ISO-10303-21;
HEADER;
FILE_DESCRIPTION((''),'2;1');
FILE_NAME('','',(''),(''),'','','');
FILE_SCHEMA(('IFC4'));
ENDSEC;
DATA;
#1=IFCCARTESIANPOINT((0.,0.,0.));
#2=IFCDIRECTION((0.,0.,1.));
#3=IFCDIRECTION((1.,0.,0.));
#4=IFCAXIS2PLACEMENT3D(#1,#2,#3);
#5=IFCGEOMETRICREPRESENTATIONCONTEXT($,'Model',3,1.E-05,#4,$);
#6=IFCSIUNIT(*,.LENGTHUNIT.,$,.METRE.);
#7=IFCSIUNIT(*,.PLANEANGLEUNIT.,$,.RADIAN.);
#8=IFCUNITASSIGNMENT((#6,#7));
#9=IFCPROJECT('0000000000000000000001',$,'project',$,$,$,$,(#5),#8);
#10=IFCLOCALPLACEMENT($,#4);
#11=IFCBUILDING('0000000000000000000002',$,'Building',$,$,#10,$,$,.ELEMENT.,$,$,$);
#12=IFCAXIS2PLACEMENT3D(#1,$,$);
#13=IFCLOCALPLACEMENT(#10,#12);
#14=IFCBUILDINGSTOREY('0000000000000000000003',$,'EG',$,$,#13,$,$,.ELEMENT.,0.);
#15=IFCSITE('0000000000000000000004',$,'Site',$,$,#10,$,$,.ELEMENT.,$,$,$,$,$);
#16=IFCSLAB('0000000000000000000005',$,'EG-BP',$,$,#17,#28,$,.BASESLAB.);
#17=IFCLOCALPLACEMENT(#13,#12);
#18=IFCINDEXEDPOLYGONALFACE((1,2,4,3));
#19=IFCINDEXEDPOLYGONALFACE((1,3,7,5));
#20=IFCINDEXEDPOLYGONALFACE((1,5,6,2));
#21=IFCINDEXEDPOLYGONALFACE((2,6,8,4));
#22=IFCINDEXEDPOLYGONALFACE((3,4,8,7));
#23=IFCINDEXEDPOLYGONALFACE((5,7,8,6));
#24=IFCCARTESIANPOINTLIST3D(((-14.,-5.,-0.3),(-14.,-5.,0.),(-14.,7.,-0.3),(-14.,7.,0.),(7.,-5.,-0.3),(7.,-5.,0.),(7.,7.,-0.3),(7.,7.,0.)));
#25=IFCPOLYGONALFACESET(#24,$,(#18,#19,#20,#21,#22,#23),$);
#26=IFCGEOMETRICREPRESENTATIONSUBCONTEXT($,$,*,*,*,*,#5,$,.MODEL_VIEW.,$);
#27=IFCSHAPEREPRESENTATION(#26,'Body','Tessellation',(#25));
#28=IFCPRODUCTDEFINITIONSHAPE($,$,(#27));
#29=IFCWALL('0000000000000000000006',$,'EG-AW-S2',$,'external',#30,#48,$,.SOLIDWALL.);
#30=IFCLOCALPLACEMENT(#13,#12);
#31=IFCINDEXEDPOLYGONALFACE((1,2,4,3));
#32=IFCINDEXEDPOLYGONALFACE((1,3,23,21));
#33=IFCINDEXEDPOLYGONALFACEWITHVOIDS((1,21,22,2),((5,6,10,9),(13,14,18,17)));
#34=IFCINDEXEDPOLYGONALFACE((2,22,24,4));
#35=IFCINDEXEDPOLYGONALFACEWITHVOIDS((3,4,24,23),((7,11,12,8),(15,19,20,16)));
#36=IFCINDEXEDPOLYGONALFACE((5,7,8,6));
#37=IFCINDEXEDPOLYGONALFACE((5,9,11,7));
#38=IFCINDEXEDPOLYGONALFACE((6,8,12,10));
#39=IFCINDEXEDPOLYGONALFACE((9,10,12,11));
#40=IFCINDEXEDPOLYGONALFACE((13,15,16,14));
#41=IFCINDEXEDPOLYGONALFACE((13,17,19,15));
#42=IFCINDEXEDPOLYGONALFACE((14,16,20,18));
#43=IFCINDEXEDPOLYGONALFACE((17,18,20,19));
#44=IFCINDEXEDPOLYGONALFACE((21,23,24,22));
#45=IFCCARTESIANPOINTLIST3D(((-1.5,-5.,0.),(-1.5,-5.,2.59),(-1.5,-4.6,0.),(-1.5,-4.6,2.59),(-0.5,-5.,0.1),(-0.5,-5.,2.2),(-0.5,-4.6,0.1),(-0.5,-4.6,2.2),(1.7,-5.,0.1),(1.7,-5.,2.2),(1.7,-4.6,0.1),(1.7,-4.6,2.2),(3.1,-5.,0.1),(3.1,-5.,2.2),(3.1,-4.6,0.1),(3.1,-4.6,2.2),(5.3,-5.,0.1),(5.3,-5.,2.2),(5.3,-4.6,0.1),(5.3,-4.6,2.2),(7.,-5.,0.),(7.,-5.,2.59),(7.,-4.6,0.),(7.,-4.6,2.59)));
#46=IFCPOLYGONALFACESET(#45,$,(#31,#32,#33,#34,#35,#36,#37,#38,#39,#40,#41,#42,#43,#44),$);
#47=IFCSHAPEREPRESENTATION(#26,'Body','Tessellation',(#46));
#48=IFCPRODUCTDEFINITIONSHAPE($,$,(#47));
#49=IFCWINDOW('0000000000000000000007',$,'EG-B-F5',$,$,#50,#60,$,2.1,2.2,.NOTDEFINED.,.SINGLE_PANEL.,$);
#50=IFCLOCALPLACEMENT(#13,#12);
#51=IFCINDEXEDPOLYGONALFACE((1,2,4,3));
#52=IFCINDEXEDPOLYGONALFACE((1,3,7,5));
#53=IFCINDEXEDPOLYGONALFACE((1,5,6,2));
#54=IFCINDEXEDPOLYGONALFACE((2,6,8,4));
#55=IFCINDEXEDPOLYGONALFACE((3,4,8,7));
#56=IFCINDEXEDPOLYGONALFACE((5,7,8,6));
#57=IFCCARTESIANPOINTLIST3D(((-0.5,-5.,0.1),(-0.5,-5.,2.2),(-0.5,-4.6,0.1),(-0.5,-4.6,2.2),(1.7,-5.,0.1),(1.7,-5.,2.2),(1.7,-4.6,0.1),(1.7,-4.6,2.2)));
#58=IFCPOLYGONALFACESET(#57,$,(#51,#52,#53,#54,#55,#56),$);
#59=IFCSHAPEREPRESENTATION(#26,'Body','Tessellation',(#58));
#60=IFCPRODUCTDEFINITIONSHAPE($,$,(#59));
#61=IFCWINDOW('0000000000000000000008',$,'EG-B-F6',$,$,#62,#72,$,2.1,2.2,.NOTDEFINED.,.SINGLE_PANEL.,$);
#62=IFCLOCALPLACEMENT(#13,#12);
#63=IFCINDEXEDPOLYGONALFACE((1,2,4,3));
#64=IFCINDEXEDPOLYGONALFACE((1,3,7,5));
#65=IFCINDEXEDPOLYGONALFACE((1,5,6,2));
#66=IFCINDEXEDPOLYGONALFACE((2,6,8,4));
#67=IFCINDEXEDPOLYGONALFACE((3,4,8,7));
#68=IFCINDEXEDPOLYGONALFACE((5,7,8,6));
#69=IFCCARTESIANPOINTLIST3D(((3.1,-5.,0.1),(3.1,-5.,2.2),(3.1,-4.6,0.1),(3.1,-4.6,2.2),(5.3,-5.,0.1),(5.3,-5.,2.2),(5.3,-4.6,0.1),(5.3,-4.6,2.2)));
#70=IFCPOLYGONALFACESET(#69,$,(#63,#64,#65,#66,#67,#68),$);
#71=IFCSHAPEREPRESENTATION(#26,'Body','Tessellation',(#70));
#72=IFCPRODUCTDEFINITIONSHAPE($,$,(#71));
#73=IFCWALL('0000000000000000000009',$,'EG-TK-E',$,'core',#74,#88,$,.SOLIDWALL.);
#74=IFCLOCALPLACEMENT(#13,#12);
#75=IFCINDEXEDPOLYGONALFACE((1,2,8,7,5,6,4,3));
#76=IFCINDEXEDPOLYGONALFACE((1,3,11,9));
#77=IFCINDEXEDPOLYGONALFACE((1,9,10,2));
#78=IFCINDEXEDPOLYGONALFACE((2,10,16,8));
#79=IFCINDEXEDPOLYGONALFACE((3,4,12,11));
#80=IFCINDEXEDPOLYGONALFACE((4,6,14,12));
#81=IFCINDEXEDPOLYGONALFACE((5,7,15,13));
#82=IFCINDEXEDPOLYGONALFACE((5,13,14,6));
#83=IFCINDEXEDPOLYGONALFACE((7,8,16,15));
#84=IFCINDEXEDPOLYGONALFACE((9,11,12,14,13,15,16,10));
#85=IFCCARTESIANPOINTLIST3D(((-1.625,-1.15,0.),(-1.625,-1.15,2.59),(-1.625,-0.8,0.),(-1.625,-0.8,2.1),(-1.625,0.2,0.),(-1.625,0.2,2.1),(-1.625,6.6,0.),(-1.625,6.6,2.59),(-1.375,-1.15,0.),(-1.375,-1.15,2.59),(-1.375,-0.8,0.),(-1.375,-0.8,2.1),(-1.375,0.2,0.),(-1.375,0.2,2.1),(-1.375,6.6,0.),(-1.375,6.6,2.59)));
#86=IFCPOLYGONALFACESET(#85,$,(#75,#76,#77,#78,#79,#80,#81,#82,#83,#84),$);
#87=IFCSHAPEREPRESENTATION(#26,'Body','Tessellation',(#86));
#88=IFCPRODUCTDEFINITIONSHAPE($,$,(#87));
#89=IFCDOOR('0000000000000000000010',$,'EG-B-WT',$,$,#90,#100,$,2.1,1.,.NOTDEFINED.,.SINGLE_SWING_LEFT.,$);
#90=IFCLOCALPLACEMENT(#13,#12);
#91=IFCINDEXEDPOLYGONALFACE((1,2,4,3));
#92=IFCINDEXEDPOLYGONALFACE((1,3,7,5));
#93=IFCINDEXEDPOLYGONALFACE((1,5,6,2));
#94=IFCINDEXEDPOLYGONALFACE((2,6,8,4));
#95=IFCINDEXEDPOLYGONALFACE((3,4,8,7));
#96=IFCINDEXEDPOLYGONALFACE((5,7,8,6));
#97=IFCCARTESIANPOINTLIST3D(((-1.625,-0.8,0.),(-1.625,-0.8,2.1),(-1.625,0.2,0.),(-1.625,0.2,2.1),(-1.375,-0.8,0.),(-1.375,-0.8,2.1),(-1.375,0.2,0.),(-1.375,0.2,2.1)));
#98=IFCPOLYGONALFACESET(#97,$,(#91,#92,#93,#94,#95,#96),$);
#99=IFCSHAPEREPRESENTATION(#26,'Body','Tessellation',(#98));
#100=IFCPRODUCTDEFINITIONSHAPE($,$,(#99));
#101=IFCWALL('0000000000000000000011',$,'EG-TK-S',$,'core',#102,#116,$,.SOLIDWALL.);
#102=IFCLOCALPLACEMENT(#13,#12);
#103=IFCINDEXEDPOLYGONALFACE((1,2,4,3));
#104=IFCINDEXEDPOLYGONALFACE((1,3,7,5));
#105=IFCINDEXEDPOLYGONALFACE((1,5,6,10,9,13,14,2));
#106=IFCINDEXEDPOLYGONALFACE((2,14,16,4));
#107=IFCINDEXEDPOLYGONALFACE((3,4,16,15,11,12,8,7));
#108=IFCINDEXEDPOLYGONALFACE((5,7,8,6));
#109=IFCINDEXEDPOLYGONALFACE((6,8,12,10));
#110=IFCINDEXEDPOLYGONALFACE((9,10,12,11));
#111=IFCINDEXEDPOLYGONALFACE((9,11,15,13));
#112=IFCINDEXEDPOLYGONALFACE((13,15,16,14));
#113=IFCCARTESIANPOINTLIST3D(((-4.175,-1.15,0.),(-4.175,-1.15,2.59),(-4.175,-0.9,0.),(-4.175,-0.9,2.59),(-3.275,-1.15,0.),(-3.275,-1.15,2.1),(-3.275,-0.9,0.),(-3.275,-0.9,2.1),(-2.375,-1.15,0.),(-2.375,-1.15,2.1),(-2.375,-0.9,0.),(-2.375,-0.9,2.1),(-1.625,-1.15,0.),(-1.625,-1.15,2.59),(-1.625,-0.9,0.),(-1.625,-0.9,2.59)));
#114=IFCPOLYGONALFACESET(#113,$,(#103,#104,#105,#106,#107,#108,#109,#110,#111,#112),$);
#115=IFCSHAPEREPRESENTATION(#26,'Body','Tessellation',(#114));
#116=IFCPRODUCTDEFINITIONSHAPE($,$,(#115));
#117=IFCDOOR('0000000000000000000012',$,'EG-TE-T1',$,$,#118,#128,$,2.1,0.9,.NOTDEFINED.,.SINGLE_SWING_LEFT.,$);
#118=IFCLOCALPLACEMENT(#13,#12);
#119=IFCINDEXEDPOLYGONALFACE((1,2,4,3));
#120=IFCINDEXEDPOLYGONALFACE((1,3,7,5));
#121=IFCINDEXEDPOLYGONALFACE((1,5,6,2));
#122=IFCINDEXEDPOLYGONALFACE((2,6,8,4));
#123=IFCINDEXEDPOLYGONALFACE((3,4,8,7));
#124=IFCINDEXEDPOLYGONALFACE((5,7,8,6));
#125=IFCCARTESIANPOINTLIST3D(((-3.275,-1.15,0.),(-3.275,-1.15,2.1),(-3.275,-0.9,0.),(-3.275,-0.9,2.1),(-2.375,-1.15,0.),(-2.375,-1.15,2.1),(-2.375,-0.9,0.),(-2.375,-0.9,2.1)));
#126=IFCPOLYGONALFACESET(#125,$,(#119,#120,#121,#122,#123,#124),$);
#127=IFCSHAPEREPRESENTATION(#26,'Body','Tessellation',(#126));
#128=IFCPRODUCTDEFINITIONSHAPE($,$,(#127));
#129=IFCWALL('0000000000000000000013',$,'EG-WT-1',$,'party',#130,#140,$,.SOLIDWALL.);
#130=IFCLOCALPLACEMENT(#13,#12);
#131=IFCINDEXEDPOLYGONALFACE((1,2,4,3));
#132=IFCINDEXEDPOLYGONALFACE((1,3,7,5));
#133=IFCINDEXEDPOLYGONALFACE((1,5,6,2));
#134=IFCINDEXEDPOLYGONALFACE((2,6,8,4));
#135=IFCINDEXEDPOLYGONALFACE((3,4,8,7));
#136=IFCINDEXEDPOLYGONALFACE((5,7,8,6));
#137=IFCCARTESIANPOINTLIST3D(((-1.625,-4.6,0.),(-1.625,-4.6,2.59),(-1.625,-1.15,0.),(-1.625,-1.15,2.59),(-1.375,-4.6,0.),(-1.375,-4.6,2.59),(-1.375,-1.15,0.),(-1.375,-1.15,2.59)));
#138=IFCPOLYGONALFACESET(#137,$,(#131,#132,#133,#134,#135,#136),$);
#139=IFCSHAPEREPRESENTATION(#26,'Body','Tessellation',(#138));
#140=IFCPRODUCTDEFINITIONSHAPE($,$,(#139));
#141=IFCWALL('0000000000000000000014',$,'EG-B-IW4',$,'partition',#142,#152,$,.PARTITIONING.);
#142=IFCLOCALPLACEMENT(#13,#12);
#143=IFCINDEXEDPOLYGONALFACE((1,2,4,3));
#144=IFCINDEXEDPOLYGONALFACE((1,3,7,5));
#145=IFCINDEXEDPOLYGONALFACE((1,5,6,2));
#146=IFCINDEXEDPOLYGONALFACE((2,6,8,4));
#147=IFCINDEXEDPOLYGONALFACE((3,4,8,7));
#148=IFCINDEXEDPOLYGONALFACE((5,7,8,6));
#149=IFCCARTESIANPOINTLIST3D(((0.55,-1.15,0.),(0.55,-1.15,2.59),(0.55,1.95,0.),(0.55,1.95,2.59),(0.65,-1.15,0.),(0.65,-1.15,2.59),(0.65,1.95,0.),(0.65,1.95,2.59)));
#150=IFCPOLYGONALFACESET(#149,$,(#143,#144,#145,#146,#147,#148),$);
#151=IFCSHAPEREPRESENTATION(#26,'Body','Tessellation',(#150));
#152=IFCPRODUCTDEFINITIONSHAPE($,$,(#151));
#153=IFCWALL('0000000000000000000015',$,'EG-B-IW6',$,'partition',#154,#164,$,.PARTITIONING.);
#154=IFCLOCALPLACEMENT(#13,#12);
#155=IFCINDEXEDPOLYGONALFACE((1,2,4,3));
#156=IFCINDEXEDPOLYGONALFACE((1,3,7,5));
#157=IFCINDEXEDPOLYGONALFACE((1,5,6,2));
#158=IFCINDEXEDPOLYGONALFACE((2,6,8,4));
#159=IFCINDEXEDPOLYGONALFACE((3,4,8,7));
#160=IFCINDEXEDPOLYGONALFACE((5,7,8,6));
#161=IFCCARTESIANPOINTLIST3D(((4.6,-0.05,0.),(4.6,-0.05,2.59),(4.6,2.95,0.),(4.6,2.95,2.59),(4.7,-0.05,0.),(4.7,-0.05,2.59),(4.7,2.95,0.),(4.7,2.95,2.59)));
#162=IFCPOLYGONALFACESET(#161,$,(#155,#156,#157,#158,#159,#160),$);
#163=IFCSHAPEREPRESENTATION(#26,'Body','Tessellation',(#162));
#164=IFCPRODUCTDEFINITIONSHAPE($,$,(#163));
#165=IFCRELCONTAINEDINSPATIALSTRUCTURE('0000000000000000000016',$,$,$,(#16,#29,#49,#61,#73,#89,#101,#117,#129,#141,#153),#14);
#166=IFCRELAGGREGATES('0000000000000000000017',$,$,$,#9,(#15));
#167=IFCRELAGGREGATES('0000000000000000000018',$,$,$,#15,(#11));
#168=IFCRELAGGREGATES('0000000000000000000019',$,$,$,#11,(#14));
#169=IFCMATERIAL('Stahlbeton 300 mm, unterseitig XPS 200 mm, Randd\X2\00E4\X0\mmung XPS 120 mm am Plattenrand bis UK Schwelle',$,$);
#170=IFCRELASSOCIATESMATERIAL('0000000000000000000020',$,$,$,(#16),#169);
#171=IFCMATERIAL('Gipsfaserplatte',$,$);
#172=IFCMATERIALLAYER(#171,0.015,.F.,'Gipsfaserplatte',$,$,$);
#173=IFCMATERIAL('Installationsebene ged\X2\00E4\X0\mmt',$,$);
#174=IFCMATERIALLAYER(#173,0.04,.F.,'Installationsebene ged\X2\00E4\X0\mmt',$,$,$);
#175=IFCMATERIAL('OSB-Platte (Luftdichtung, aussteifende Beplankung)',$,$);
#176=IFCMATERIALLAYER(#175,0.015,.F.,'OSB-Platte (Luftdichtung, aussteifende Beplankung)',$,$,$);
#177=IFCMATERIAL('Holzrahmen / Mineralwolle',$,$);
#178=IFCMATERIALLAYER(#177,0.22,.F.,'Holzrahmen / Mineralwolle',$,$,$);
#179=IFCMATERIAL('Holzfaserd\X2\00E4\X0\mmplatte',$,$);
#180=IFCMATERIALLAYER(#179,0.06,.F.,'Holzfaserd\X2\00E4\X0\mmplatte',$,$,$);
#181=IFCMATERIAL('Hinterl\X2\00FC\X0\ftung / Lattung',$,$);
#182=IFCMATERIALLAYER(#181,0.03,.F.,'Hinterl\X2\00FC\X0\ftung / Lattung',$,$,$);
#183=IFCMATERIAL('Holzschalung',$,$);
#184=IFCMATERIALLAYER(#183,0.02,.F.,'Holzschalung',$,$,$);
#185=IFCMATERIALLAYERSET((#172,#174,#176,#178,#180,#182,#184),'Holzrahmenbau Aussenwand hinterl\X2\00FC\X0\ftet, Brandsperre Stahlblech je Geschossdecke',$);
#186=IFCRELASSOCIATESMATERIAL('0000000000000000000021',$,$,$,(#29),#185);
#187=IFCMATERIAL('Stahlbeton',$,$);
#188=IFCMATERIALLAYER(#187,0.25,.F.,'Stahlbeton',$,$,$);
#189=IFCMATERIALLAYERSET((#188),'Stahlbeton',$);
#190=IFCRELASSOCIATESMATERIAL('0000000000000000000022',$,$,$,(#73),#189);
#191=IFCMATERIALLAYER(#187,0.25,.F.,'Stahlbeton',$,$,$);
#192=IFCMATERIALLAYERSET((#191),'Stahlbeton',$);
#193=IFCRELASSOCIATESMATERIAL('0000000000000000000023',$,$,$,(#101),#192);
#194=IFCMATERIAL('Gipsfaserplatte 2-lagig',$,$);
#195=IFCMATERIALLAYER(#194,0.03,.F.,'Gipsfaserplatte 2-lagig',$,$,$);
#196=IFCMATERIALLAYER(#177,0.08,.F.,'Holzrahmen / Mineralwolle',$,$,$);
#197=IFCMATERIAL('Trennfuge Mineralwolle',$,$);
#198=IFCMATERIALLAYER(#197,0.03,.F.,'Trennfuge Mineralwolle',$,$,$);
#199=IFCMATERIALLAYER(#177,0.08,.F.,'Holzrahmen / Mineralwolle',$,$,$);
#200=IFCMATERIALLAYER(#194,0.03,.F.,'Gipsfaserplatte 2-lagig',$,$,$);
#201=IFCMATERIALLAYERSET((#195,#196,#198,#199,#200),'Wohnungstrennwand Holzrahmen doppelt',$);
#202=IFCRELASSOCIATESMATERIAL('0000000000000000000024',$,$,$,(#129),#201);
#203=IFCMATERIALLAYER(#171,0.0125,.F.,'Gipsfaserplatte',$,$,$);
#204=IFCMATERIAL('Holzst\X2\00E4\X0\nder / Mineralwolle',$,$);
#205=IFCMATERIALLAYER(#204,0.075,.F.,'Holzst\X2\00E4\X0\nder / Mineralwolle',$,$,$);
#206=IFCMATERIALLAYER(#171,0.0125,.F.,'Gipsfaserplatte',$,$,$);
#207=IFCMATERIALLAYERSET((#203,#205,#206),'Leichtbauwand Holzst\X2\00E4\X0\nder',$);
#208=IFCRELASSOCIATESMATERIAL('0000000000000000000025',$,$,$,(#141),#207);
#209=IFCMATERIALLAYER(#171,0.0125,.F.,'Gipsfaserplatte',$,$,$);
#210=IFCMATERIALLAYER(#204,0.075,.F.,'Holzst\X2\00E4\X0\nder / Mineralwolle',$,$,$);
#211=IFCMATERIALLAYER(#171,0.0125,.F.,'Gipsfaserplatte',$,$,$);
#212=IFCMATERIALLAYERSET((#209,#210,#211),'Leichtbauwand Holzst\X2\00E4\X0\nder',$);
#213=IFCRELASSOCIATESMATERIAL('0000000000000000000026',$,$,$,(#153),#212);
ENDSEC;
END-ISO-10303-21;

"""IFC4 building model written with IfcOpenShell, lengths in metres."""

from ifc_helpers import new_model, si_unit, frame, frame_2d, origin, origin_with_axes, place, context, subcontext, project, spatial, polyline, rectangle, outline, extrude, material, layer, layer_set, element, fill, save


model = new_model("IFC4")

# Units and contexts
model_context = context("Model", 3, precision=1e-05, world=origin_with_axes())
sub_context = subcontext(model_context, None, None, "MODEL_VIEW")
ifc_project = project(units=[si_unit("LENGTHUNIT", "METRE"), si_unit("PLANEANGLEUNIT", "RADIAN")], contexts=[model_context])

# Site, building, storey
placement = place(None, origin_with_axes())
site = spatial("IfcSite", under=ifc_project, at=placement, Name="Site", CompositionType="ELEMENT")
building = spatial("IfcBuilding", under=site, at=placement, Name="Building", CompositionType="ELEMENT")
storey_placement = place(placement, origin())
storey = spatial("IfcBuildingStorey", under=building, at=storey_placement, Name="EG", CompositionType="ELEMENT", Elevation=0.0)

# Slab
ifc_material_1 = material(Name="Stahlbeton 300 mm, unterseitig XPS 200 mm, Randdämmung XPS 120 mm am Plattenrand bis UK Schwelle")
slab_placement = place(storey_placement, frame((0.0, 0.0, -0.3)))
element("IfcSlab", 1, at=slab_placement, inside=storey, material=ifc_material_1, Name="EG-BP", PredefinedType="BASESLAB", context=sub_context, shape_type="SweptSolid", body=[
    extrude(outline(polyline([(-14.0, -5.0), (7.0, -5.0), (7.0, 7.0), (-14.0, 7.0), (-14.0, -5.0)])), origin(), (0.0, 0.0, 1.0), 0.3),
])

# Wall, openings, windows
ifc_material_2 = material(Name="Gipsfaserplatte")
ifc_layer_1 = layer(ifc_material_2, 0.015, ventilated=False, Name="Gipsfaserplatte")
ifc_material_3 = material(Name="Installationsebene gedämmt")
ifc_layer_2 = layer(ifc_material_3, 0.04, ventilated=False, Name="Installationsebene gedämmt")
ifc_material_4 = material(Name="OSB-Platte (Luftdichtung, aussteifende Beplankung)")
ifc_layer_3 = layer(ifc_material_4, 0.015, ventilated=False, Name="OSB-Platte (Luftdichtung, aussteifende Beplankung)")
ifc_material_5 = material(Name="Holzrahmen / Mineralwolle")
ifc_layer_4 = layer(ifc_material_5, 0.22, ventilated=False, Name="Holzrahmen / Mineralwolle")
ifc_material_6 = material(Name="Holzfaserdämmplatte")
ifc_layer_5 = layer(ifc_material_6, 0.06, ventilated=False, Name="Holzfaserdämmplatte")
ifc_material_7 = material(Name="Hinterlüftung / Lattung")
ifc_layer_6 = layer(ifc_material_7, 0.03, ventilated=False, Name="Hinterlüftung / Lattung")
ifc_material_8 = material(Name="Holzschalung")
ifc_layer_7 = layer(ifc_material_8, 0.02, ventilated=False, Name="Holzschalung")
ifc_layer_set_1 = layer_set([ifc_layer_1, ifc_layer_2, ifc_layer_3, ifc_layer_4, ifc_layer_5, ifc_layer_6, ifc_layer_7], Name="Holzrahmenbau Aussenwand hinterlüftet, Brandsperre Stahlblech je Geschossdecke")
wall_1_placement = place(storey_placement, frame((7.0, -4.8, 0.0), z_axis=(0.0, 0.0, 1.0), x_axis=(-1.0, 0.0, 0.0)))
wall_1 = element("IfcWall", 2, at=wall_1_placement, inside=storey, material=ifc_layer_set_1, Name="EG-AW-S2", ObjectType="external", PredefinedType="SOLIDWALL", context=sub_context, shape_type="SweptSolid", body=[
    extrude(rectangle(XDim=8.5, YDim=0.4, at=frame_2d((4.25, 0.0))), origin(), (0.0, 0.0, 1.0), 2.59),
])
opening_1_placement = place(wall_1_placement, frame((6.4, 0.25, 0.1), z_axis=(0.0, -1.0, 0.0), x_axis=(1.0, 0.0, 0.0)))
opening_1 = element("IfcOpeningElement", 3, at=opening_1_placement, cuts=wall_1, PredefinedType="OPENING", context=sub_context, shape_type="SweptSolid", body=[
    extrude(rectangle(XDim=2.2, YDim=2.1, at=frame_2d((0.0, 1.05))), origin(), (0.0, 0.0, 1.0), 0.5),
])
opening_2_placement = place(wall_1_placement, frame((2.8, 0.25, 0.1), z_axis=(0.0, -1.0, 0.0), x_axis=(1.0, 0.0, 0.0)))
opening_2 = element("IfcOpeningElement", 4, at=opening_2_placement, cuts=wall_1, PredefinedType="OPENING", context=sub_context, shape_type="SweptSolid", body=[
    extrude(rectangle(XDim=2.2, YDim=2.1, at=frame_2d((0.0, 1.05))), origin(), (0.0, 0.0, 1.0), 0.5),
])
window_1_placement = place(wall_1_placement, frame((6.4, 0.2, 0.1), z_axis=(0.0, -1.0, 0.0), x_axis=(1.0, 0.0, 0.0)))
window_1 = element("IfcWindow", 5, at=window_1_placement, inside=storey, Name="EG-B-F5", OverallHeight=2.1, OverallWidth=2.2, PartitioningType="SINGLE_PANEL", PredefinedType="NOTDEFINED", context=sub_context, shape_type="SweptSolid", body=[
    extrude(rectangle(XDim=2.2, YDim=2.1, at=frame_2d((0.0, 1.05))), origin(), (0.0, 0.0, 1.0), 0.4),
])
fill(opening_1, window_1)
window_2_placement = place(wall_1_placement, frame((2.8, 0.2, 0.1), z_axis=(0.0, -1.0, 0.0), x_axis=(1.0, 0.0, 0.0)))
window_2 = element("IfcWindow", 6, at=window_2_placement, inside=storey, Name="EG-B-F6", OverallHeight=2.1, OverallWidth=2.2, PartitioningType="SINGLE_PANEL", PredefinedType="NOTDEFINED", context=sub_context, shape_type="SweptSolid", body=[
    extrude(rectangle(XDim=2.2, YDim=2.1, at=frame_2d((0.0, 1.05))), origin(), (0.0, 0.0, 1.0), 0.4),
])
fill(opening_2, window_2)

# Walls, openings, doors
ifc_material_9 = material(Name="Stahlbeton")
ifc_layer_8 = layer(ifc_material_9, 0.25, ventilated=False, Name="Stahlbeton")
ifc_layer_set_2 = layer_set([ifc_layer_8], Name="Stahlbeton")
wall_2_placement = place(storey_placement, frame((-1.5, -1.15, 0.0), z_axis=(0.0, 0.0, 1.0), x_axis=(0.0, 1.0, 0.0)))
wall_2 = element("IfcWall", 7, at=wall_2_placement, inside=storey, material=ifc_layer_set_2, Name="EG-TK-E", ObjectType="core", PredefinedType="SOLIDWALL", context=sub_context, shape_type="SweptSolid", body=[
    extrude(rectangle(XDim=7.75, YDim=0.25, at=frame_2d((3.875, 0.0))), origin(), (0.0, 0.0, 1.0), 2.59),
])
opening_3_placement = place(wall_2_placement, frame((0.85, 0.175, 0.0), z_axis=(0.0, -1.0, 0.0), x_axis=(1.0, 0.0, 0.0)))
opening_3 = element("IfcOpeningElement", 8, at=opening_3_placement, cuts=wall_2, PredefinedType="OPENING", context=sub_context, shape_type="SweptSolid", body=[
    extrude(rectangle(XDim=1.0, YDim=2.1, at=frame_2d((0.0, 1.05))), origin(), (0.0, 0.0, 1.0), 0.35),
])
door_1_placement = place(wall_2_placement, frame((0.85, 0.125, 0.0), z_axis=(0.0, -1.0, 0.0), x_axis=(1.0, 0.0, 0.0)))
door_1 = element("IfcDoor", 9, at=door_1_placement, inside=storey, Name="EG-B-WT", OperationType="SINGLE_SWING_LEFT", OverallHeight=2.1, OverallWidth=1.0, PredefinedType="NOTDEFINED", context=sub_context, shape_type="SweptSolid", body=[
    extrude(rectangle(XDim=1.0, YDim=2.1, at=frame_2d((0.0, 1.05))), origin(), (0.0, 0.0, 1.0), 0.25),
])
fill(opening_3, door_1)
ifc_layer_9 = layer(ifc_material_9, 0.25, ventilated=False, Name="Stahlbeton")
ifc_layer_set_3 = layer_set([ifc_layer_9], Name="Stahlbeton")
wall_3_placement = place(storey_placement, frame((-4.175, -1.025, 0.0), z_axis=(0.0, 0.0, 1.0), x_axis=(1.0, 0.0, 0.0)))
wall_3 = element("IfcWall", 10, at=wall_3_placement, inside=storey, material=ifc_layer_set_3, Name="EG-TK-S", ObjectType="core", PredefinedType="SOLIDWALL", context=sub_context, shape_type="SweptSolid", body=[
    extrude(rectangle(XDim=2.55, YDim=0.25, at=frame_2d((1.275, 0.0))), origin(), (0.0, 0.0, 1.0), 2.59),
])
opening_4_placement = place(wall_3_placement, frame((1.35, 0.175, 0.0), z_axis=(0.0, -1.0, 0.0), x_axis=(1.0, 0.0, 0.0)))
opening_4 = element("IfcOpeningElement", 11, at=opening_4_placement, cuts=wall_3, PredefinedType="OPENING", context=sub_context, shape_type="SweptSolid", body=[
    extrude(rectangle(XDim=0.9, YDim=2.1, at=frame_2d((0.0, 1.05))), origin(), (0.0, 0.0, 1.0), 0.35),
])
door_2_placement = place(wall_3_placement, frame((1.35, 0.125, 0.0), z_axis=(0.0, -1.0, 0.0), x_axis=(1.0, 0.0, 0.0)))
door_2 = element("IfcDoor", 12, at=door_2_placement, inside=storey, Name="EG-TE-T1", OperationType="SINGLE_SWING_LEFT", OverallHeight=2.1, OverallWidth=0.9, PredefinedType="NOTDEFINED", context=sub_context, shape_type="SweptSolid", body=[
    extrude(rectangle(XDim=0.9, YDim=2.1, at=frame_2d((0.0, 1.05))), origin(), (0.0, 0.0, 1.0), 0.25),
])
fill(opening_4, door_2)

# Walls
ifc_material_10 = material(Name="Gipsfaserplatte 2-lagig")
ifc_layer_10 = layer(ifc_material_10, 0.03, ventilated=False, Name="Gipsfaserplatte 2-lagig")
ifc_layer_11 = layer(ifc_material_5, 0.08, ventilated=False, Name="Holzrahmen / Mineralwolle")
ifc_material_11 = material(Name="Trennfuge Mineralwolle")
ifc_layer_12 = layer(ifc_material_11, 0.03, ventilated=False, Name="Trennfuge Mineralwolle")
ifc_layer_13 = layer(ifc_material_5, 0.08, ventilated=False, Name="Holzrahmen / Mineralwolle")
ifc_layer_14 = layer(ifc_material_10, 0.03, ventilated=False, Name="Gipsfaserplatte 2-lagig")
ifc_layer_set_4 = layer_set([ifc_layer_10, ifc_layer_11, ifc_layer_12, ifc_layer_13, ifc_layer_14], Name="Wohnungstrennwand Holzrahmen doppelt")
wall_4_placement = place(storey_placement, frame((-1.5, -1.15, 0.0), z_axis=(0.0, 0.0, 1.0), x_axis=(0.0, -1.0, 0.0)))
element("IfcWall", 13, at=wall_4_placement, inside=storey, material=ifc_layer_set_4, Name="EG-WT-1", ObjectType="party", PredefinedType="SOLIDWALL", context=sub_context, shape_type="SweptSolid", body=[
    extrude(rectangle(XDim=3.45, YDim=0.25, at=frame_2d((1.725, 0.0))), origin(), (0.0, 0.0, 1.0), 2.59),
])
ifc_layer_15 = layer(ifc_material_2, 0.0125, ventilated=False, Name="Gipsfaserplatte")
ifc_material_12 = material(Name="Holzständer / Mineralwolle")
ifc_layer_16 = layer(ifc_material_12, 0.075, ventilated=False, Name="Holzständer / Mineralwolle")
ifc_layer_17 = layer(ifc_material_2, 0.0125, ventilated=False, Name="Gipsfaserplatte")
ifc_layer_set_5 = layer_set([ifc_layer_15, ifc_layer_16, ifc_layer_17], Name="Leichtbauwand Holzständer")
wall_5_placement = place(storey_placement, frame((0.6, -1.15, 0.0), z_axis=(0.0, 0.0, 1.0), x_axis=(0.0, 1.0, 0.0)))
element("IfcWall", 14, at=wall_5_placement, inside=storey, material=ifc_layer_set_5, Name="EG-B-IW4", ObjectType="partition", PredefinedType="PARTITIONING", context=sub_context, shape_type="SweptSolid", body=[
    extrude(rectangle(XDim=3.1, YDim=0.1, at=frame_2d((1.55, 0.0))), origin(), (0.0, 0.0, 1.0), 2.59),
])
ifc_layer_18 = layer(ifc_material_2, 0.0125, ventilated=False, Name="Gipsfaserplatte")
ifc_layer_19 = layer(ifc_material_12, 0.075, ventilated=False, Name="Holzständer / Mineralwolle")
ifc_layer_20 = layer(ifc_material_2, 0.0125, ventilated=False, Name="Gipsfaserplatte")
ifc_layer_set_6 = layer_set([ifc_layer_18, ifc_layer_19, ifc_layer_20], Name="Leichtbauwand Holzständer")
wall_6_placement = place(storey_placement, frame((4.65, -0.05, 0.0), z_axis=(0.0, 0.0, 1.0), x_axis=(0.0, 1.0, 0.0)))
element("IfcWall", 15, at=wall_6_placement, inside=storey, material=ifc_layer_set_6, Name="EG-B-IW6", ObjectType="partition", PredefinedType="PARTITIONING", context=sub_context, shape_type="SweptSolid", body=[
    extrude(rectangle(XDim=3.0, YDim=0.1, at=frame_2d((1.5, 0.0))), origin(), (0.0, 0.0, 1.0), 2.59),
])

save(model, "model.ifc")
